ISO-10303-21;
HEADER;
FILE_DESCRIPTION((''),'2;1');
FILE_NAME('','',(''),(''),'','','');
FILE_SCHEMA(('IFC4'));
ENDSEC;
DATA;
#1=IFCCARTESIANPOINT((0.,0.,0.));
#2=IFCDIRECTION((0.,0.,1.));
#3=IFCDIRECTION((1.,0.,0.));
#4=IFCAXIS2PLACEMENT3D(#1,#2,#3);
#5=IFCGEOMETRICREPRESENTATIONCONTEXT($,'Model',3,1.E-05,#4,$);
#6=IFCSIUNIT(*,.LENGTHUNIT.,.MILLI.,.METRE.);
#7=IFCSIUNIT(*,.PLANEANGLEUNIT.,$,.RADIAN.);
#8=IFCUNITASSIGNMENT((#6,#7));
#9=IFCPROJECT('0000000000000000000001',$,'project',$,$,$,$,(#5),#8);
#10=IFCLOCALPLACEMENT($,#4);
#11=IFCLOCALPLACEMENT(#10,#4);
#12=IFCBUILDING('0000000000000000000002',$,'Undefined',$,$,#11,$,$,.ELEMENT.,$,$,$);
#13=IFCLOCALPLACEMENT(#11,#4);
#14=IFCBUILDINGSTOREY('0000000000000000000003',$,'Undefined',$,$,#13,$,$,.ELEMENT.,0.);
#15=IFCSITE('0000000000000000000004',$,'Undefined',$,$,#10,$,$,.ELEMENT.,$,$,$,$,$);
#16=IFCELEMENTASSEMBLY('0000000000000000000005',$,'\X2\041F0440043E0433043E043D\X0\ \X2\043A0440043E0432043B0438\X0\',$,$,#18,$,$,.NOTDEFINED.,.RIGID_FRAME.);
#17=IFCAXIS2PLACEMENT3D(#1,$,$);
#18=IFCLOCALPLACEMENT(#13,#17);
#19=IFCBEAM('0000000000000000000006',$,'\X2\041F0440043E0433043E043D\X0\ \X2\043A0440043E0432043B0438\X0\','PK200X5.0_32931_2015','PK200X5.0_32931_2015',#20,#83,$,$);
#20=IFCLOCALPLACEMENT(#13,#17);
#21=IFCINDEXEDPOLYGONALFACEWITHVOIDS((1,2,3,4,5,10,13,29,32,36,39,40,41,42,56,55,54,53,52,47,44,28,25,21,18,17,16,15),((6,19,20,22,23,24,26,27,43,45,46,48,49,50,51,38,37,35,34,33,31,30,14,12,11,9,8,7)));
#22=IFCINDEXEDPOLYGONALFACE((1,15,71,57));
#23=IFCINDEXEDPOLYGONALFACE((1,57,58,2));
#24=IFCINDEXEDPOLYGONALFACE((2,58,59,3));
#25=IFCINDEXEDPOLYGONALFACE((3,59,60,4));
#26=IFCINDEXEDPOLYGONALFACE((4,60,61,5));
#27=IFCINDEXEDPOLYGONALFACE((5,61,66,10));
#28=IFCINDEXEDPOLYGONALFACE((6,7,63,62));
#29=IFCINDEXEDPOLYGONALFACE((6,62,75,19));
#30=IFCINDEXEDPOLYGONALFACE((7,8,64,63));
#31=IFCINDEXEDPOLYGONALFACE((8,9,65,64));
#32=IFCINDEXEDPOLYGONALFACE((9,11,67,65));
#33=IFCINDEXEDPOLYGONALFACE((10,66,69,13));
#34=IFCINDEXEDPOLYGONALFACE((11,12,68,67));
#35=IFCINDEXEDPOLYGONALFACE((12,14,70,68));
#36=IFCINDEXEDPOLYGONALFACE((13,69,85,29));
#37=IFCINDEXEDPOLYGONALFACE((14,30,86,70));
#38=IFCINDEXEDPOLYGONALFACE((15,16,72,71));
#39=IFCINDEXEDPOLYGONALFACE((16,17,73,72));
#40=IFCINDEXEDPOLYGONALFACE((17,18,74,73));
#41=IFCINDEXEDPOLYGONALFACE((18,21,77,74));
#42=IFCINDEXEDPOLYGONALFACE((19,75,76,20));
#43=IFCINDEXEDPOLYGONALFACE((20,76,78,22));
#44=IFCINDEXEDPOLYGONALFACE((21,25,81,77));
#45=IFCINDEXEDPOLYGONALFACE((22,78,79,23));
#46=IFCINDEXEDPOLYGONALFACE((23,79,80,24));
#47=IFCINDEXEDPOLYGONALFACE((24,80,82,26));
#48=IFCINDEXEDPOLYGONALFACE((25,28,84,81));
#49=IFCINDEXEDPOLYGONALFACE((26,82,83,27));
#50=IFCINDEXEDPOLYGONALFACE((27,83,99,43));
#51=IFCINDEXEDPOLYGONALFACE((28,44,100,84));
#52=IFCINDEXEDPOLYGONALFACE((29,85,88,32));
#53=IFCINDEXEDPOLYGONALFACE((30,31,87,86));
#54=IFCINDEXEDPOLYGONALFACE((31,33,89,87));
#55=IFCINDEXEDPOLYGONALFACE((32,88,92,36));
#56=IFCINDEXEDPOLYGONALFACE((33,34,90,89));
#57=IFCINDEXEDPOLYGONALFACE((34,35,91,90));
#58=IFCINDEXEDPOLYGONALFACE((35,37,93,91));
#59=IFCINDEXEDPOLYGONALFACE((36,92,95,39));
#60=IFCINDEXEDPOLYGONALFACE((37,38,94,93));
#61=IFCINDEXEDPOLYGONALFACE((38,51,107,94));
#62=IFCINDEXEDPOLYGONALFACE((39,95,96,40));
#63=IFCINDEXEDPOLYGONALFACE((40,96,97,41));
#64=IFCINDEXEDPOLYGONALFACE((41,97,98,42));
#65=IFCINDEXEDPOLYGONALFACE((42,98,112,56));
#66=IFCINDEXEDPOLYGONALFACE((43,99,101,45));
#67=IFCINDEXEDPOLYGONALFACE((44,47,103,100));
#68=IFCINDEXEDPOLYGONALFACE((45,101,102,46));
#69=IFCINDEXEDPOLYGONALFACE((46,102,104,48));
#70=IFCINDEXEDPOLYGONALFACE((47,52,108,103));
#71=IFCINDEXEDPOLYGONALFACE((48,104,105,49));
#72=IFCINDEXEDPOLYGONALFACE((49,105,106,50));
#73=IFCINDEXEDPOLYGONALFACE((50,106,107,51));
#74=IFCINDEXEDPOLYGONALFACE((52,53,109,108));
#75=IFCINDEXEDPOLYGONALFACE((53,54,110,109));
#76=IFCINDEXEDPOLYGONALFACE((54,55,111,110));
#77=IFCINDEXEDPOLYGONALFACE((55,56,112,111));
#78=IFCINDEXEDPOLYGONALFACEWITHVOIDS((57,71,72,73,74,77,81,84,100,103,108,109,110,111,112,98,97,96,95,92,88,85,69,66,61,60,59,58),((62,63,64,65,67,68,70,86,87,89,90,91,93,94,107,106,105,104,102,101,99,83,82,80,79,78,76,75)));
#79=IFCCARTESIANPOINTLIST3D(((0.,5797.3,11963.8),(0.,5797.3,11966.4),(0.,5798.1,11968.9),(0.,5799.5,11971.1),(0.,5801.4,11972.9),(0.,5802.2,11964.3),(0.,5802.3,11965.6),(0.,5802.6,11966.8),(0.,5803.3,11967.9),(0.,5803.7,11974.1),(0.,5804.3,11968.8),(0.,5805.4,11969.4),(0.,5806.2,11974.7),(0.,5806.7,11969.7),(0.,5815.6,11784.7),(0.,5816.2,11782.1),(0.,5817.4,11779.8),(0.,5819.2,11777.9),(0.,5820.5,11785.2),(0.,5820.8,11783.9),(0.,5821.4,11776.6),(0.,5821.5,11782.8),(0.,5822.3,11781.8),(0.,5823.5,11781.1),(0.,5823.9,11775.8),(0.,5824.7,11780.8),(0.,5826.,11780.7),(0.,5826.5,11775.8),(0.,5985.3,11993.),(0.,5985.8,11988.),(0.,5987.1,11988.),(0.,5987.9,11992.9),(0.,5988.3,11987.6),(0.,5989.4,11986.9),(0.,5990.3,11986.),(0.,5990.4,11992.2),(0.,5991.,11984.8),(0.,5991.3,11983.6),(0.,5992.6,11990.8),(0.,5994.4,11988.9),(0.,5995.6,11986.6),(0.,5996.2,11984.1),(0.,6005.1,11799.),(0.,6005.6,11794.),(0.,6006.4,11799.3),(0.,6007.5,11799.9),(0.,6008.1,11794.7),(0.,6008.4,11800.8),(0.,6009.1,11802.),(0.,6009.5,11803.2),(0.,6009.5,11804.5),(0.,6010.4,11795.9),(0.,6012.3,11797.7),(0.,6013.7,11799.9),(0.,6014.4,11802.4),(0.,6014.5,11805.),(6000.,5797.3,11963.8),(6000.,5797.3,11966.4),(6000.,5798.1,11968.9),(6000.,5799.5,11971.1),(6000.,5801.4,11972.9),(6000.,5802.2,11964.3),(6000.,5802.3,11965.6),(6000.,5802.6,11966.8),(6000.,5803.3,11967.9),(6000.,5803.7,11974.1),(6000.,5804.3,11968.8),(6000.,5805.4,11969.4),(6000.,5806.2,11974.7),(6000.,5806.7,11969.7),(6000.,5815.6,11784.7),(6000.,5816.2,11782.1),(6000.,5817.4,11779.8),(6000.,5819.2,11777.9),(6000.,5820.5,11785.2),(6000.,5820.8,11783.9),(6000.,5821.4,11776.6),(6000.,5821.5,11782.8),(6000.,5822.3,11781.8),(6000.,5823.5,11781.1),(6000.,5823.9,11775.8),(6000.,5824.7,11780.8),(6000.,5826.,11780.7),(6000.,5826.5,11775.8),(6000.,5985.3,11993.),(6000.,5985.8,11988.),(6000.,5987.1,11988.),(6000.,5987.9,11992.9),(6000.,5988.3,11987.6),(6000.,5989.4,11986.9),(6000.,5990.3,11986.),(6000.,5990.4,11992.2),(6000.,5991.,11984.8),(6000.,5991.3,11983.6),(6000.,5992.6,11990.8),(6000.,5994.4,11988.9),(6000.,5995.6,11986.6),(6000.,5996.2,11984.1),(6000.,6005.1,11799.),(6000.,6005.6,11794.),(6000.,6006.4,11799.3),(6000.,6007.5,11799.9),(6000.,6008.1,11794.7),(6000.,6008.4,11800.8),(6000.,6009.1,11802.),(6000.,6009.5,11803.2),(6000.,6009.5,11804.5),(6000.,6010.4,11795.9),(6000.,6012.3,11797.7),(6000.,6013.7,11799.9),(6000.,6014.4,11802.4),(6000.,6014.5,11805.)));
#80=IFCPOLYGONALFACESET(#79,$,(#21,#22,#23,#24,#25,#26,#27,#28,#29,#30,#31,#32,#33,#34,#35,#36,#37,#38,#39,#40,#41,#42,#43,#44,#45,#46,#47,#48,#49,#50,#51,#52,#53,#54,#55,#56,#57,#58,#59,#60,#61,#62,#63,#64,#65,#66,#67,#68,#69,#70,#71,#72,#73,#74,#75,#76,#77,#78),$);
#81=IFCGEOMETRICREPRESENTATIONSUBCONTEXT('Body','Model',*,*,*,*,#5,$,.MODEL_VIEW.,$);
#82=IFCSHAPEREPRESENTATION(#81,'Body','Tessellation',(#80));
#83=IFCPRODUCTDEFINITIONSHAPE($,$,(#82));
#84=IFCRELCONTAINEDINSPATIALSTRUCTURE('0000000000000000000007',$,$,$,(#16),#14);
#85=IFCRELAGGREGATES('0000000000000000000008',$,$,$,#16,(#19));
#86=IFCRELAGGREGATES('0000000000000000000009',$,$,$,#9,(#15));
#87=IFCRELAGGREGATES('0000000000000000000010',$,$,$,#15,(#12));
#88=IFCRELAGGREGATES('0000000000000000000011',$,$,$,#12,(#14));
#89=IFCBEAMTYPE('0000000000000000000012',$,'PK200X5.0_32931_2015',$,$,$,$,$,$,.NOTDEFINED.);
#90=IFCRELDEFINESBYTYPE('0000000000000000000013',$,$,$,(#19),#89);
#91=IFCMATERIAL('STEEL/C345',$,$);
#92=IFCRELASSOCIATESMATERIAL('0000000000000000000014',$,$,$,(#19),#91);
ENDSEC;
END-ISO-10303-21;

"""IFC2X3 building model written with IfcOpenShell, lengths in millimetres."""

from ifc_helpers import new_model, si_unit, frame, origin_with_axes, origin_2d_with_axis, place, context, subcontext, project, spatial, hollow_rectangle, extrude, material, type_object, element, aggregate, save


model = new_model("IFC2X3")

# Units and contexts
model_context = context("Model", 3, precision=1e-05, world=origin_with_axes())
body_context = subcontext(model_context, "Body", "Model", "MODEL_VIEW")
ifc_project = project(units=[si_unit("LENGTHUNIT", "METRE", prefix="MILLI"), si_unit("PLANEANGLEUNIT", "RADIAN")], contexts=[model_context])

# Site, building, storey
site_placement = place(None, origin_with_axes())
site = spatial("IfcSite", under=ifc_project, at=site_placement, Name="Undefined", CompositionType="ELEMENT")
building_placement = place(site_placement, origin_with_axes())
building = spatial("IfcBuilding", under=site, at=building_placement, Name="Undefined", CompositionType="ELEMENT")
storey_placement = place(building_placement, origin_with_axes())
storey = spatial("IfcBuildingStorey", under=building, at=storey_placement, Name="Undefined", CompositionType="ELEMENT", Elevation=0.0)

# Element assembly, beam
ifc_material_1 = material(Name="STEEL/C345")
beam_type_1 = type_object("IfcBeamType", Name="PK200X5.0_32931_2015", PredefinedType="NOTDEFINED")
assembly_1_placement = place(storey_placement, origin_with_axes())
assembly_1 = element("IfcElementAssembly", 1, at=assembly_1_placement, inside=storey, Name="Прогон кровли", AssemblyPlace="NOTDEFINED", PredefinedType="RIGID_FRAME")
beam_1_placement = place(assembly_1_placement, frame((6000.0, 5905.9, 11884.4), z_axis=(0.0, -0.101645, 0.994821), x_axis=(-1.0, 0.0, 0.0)))
beam_1 = element("IfcBeam", 2, at=beam_1_placement, type_object=beam_type_1, material=ifc_material_1, Name="Прогон кровли", Description="PK200X5.0_32931_2015", ObjectType="PK200X5.0_32931_2015", context=body_context, shape_type="SweptSolid", body=[
    extrude(hollow_rectangle(XDim=200.0, YDim=200.0, WallThickness=5.0, InnerFilletRadius=5.0, OuterFilletRadius=10.0, at=origin_2d_with_axis()), frame((6000.0, 0.0, 0.0), z_axis=(-1.0, 0.0, 0.0), x_axis=(0.0, -1.0, 0.0)), (0.0, 0.0, 1.0), 6000.0),
])
aggregate(assembly_1, [beam_1])

save(model, "model.ifc")
